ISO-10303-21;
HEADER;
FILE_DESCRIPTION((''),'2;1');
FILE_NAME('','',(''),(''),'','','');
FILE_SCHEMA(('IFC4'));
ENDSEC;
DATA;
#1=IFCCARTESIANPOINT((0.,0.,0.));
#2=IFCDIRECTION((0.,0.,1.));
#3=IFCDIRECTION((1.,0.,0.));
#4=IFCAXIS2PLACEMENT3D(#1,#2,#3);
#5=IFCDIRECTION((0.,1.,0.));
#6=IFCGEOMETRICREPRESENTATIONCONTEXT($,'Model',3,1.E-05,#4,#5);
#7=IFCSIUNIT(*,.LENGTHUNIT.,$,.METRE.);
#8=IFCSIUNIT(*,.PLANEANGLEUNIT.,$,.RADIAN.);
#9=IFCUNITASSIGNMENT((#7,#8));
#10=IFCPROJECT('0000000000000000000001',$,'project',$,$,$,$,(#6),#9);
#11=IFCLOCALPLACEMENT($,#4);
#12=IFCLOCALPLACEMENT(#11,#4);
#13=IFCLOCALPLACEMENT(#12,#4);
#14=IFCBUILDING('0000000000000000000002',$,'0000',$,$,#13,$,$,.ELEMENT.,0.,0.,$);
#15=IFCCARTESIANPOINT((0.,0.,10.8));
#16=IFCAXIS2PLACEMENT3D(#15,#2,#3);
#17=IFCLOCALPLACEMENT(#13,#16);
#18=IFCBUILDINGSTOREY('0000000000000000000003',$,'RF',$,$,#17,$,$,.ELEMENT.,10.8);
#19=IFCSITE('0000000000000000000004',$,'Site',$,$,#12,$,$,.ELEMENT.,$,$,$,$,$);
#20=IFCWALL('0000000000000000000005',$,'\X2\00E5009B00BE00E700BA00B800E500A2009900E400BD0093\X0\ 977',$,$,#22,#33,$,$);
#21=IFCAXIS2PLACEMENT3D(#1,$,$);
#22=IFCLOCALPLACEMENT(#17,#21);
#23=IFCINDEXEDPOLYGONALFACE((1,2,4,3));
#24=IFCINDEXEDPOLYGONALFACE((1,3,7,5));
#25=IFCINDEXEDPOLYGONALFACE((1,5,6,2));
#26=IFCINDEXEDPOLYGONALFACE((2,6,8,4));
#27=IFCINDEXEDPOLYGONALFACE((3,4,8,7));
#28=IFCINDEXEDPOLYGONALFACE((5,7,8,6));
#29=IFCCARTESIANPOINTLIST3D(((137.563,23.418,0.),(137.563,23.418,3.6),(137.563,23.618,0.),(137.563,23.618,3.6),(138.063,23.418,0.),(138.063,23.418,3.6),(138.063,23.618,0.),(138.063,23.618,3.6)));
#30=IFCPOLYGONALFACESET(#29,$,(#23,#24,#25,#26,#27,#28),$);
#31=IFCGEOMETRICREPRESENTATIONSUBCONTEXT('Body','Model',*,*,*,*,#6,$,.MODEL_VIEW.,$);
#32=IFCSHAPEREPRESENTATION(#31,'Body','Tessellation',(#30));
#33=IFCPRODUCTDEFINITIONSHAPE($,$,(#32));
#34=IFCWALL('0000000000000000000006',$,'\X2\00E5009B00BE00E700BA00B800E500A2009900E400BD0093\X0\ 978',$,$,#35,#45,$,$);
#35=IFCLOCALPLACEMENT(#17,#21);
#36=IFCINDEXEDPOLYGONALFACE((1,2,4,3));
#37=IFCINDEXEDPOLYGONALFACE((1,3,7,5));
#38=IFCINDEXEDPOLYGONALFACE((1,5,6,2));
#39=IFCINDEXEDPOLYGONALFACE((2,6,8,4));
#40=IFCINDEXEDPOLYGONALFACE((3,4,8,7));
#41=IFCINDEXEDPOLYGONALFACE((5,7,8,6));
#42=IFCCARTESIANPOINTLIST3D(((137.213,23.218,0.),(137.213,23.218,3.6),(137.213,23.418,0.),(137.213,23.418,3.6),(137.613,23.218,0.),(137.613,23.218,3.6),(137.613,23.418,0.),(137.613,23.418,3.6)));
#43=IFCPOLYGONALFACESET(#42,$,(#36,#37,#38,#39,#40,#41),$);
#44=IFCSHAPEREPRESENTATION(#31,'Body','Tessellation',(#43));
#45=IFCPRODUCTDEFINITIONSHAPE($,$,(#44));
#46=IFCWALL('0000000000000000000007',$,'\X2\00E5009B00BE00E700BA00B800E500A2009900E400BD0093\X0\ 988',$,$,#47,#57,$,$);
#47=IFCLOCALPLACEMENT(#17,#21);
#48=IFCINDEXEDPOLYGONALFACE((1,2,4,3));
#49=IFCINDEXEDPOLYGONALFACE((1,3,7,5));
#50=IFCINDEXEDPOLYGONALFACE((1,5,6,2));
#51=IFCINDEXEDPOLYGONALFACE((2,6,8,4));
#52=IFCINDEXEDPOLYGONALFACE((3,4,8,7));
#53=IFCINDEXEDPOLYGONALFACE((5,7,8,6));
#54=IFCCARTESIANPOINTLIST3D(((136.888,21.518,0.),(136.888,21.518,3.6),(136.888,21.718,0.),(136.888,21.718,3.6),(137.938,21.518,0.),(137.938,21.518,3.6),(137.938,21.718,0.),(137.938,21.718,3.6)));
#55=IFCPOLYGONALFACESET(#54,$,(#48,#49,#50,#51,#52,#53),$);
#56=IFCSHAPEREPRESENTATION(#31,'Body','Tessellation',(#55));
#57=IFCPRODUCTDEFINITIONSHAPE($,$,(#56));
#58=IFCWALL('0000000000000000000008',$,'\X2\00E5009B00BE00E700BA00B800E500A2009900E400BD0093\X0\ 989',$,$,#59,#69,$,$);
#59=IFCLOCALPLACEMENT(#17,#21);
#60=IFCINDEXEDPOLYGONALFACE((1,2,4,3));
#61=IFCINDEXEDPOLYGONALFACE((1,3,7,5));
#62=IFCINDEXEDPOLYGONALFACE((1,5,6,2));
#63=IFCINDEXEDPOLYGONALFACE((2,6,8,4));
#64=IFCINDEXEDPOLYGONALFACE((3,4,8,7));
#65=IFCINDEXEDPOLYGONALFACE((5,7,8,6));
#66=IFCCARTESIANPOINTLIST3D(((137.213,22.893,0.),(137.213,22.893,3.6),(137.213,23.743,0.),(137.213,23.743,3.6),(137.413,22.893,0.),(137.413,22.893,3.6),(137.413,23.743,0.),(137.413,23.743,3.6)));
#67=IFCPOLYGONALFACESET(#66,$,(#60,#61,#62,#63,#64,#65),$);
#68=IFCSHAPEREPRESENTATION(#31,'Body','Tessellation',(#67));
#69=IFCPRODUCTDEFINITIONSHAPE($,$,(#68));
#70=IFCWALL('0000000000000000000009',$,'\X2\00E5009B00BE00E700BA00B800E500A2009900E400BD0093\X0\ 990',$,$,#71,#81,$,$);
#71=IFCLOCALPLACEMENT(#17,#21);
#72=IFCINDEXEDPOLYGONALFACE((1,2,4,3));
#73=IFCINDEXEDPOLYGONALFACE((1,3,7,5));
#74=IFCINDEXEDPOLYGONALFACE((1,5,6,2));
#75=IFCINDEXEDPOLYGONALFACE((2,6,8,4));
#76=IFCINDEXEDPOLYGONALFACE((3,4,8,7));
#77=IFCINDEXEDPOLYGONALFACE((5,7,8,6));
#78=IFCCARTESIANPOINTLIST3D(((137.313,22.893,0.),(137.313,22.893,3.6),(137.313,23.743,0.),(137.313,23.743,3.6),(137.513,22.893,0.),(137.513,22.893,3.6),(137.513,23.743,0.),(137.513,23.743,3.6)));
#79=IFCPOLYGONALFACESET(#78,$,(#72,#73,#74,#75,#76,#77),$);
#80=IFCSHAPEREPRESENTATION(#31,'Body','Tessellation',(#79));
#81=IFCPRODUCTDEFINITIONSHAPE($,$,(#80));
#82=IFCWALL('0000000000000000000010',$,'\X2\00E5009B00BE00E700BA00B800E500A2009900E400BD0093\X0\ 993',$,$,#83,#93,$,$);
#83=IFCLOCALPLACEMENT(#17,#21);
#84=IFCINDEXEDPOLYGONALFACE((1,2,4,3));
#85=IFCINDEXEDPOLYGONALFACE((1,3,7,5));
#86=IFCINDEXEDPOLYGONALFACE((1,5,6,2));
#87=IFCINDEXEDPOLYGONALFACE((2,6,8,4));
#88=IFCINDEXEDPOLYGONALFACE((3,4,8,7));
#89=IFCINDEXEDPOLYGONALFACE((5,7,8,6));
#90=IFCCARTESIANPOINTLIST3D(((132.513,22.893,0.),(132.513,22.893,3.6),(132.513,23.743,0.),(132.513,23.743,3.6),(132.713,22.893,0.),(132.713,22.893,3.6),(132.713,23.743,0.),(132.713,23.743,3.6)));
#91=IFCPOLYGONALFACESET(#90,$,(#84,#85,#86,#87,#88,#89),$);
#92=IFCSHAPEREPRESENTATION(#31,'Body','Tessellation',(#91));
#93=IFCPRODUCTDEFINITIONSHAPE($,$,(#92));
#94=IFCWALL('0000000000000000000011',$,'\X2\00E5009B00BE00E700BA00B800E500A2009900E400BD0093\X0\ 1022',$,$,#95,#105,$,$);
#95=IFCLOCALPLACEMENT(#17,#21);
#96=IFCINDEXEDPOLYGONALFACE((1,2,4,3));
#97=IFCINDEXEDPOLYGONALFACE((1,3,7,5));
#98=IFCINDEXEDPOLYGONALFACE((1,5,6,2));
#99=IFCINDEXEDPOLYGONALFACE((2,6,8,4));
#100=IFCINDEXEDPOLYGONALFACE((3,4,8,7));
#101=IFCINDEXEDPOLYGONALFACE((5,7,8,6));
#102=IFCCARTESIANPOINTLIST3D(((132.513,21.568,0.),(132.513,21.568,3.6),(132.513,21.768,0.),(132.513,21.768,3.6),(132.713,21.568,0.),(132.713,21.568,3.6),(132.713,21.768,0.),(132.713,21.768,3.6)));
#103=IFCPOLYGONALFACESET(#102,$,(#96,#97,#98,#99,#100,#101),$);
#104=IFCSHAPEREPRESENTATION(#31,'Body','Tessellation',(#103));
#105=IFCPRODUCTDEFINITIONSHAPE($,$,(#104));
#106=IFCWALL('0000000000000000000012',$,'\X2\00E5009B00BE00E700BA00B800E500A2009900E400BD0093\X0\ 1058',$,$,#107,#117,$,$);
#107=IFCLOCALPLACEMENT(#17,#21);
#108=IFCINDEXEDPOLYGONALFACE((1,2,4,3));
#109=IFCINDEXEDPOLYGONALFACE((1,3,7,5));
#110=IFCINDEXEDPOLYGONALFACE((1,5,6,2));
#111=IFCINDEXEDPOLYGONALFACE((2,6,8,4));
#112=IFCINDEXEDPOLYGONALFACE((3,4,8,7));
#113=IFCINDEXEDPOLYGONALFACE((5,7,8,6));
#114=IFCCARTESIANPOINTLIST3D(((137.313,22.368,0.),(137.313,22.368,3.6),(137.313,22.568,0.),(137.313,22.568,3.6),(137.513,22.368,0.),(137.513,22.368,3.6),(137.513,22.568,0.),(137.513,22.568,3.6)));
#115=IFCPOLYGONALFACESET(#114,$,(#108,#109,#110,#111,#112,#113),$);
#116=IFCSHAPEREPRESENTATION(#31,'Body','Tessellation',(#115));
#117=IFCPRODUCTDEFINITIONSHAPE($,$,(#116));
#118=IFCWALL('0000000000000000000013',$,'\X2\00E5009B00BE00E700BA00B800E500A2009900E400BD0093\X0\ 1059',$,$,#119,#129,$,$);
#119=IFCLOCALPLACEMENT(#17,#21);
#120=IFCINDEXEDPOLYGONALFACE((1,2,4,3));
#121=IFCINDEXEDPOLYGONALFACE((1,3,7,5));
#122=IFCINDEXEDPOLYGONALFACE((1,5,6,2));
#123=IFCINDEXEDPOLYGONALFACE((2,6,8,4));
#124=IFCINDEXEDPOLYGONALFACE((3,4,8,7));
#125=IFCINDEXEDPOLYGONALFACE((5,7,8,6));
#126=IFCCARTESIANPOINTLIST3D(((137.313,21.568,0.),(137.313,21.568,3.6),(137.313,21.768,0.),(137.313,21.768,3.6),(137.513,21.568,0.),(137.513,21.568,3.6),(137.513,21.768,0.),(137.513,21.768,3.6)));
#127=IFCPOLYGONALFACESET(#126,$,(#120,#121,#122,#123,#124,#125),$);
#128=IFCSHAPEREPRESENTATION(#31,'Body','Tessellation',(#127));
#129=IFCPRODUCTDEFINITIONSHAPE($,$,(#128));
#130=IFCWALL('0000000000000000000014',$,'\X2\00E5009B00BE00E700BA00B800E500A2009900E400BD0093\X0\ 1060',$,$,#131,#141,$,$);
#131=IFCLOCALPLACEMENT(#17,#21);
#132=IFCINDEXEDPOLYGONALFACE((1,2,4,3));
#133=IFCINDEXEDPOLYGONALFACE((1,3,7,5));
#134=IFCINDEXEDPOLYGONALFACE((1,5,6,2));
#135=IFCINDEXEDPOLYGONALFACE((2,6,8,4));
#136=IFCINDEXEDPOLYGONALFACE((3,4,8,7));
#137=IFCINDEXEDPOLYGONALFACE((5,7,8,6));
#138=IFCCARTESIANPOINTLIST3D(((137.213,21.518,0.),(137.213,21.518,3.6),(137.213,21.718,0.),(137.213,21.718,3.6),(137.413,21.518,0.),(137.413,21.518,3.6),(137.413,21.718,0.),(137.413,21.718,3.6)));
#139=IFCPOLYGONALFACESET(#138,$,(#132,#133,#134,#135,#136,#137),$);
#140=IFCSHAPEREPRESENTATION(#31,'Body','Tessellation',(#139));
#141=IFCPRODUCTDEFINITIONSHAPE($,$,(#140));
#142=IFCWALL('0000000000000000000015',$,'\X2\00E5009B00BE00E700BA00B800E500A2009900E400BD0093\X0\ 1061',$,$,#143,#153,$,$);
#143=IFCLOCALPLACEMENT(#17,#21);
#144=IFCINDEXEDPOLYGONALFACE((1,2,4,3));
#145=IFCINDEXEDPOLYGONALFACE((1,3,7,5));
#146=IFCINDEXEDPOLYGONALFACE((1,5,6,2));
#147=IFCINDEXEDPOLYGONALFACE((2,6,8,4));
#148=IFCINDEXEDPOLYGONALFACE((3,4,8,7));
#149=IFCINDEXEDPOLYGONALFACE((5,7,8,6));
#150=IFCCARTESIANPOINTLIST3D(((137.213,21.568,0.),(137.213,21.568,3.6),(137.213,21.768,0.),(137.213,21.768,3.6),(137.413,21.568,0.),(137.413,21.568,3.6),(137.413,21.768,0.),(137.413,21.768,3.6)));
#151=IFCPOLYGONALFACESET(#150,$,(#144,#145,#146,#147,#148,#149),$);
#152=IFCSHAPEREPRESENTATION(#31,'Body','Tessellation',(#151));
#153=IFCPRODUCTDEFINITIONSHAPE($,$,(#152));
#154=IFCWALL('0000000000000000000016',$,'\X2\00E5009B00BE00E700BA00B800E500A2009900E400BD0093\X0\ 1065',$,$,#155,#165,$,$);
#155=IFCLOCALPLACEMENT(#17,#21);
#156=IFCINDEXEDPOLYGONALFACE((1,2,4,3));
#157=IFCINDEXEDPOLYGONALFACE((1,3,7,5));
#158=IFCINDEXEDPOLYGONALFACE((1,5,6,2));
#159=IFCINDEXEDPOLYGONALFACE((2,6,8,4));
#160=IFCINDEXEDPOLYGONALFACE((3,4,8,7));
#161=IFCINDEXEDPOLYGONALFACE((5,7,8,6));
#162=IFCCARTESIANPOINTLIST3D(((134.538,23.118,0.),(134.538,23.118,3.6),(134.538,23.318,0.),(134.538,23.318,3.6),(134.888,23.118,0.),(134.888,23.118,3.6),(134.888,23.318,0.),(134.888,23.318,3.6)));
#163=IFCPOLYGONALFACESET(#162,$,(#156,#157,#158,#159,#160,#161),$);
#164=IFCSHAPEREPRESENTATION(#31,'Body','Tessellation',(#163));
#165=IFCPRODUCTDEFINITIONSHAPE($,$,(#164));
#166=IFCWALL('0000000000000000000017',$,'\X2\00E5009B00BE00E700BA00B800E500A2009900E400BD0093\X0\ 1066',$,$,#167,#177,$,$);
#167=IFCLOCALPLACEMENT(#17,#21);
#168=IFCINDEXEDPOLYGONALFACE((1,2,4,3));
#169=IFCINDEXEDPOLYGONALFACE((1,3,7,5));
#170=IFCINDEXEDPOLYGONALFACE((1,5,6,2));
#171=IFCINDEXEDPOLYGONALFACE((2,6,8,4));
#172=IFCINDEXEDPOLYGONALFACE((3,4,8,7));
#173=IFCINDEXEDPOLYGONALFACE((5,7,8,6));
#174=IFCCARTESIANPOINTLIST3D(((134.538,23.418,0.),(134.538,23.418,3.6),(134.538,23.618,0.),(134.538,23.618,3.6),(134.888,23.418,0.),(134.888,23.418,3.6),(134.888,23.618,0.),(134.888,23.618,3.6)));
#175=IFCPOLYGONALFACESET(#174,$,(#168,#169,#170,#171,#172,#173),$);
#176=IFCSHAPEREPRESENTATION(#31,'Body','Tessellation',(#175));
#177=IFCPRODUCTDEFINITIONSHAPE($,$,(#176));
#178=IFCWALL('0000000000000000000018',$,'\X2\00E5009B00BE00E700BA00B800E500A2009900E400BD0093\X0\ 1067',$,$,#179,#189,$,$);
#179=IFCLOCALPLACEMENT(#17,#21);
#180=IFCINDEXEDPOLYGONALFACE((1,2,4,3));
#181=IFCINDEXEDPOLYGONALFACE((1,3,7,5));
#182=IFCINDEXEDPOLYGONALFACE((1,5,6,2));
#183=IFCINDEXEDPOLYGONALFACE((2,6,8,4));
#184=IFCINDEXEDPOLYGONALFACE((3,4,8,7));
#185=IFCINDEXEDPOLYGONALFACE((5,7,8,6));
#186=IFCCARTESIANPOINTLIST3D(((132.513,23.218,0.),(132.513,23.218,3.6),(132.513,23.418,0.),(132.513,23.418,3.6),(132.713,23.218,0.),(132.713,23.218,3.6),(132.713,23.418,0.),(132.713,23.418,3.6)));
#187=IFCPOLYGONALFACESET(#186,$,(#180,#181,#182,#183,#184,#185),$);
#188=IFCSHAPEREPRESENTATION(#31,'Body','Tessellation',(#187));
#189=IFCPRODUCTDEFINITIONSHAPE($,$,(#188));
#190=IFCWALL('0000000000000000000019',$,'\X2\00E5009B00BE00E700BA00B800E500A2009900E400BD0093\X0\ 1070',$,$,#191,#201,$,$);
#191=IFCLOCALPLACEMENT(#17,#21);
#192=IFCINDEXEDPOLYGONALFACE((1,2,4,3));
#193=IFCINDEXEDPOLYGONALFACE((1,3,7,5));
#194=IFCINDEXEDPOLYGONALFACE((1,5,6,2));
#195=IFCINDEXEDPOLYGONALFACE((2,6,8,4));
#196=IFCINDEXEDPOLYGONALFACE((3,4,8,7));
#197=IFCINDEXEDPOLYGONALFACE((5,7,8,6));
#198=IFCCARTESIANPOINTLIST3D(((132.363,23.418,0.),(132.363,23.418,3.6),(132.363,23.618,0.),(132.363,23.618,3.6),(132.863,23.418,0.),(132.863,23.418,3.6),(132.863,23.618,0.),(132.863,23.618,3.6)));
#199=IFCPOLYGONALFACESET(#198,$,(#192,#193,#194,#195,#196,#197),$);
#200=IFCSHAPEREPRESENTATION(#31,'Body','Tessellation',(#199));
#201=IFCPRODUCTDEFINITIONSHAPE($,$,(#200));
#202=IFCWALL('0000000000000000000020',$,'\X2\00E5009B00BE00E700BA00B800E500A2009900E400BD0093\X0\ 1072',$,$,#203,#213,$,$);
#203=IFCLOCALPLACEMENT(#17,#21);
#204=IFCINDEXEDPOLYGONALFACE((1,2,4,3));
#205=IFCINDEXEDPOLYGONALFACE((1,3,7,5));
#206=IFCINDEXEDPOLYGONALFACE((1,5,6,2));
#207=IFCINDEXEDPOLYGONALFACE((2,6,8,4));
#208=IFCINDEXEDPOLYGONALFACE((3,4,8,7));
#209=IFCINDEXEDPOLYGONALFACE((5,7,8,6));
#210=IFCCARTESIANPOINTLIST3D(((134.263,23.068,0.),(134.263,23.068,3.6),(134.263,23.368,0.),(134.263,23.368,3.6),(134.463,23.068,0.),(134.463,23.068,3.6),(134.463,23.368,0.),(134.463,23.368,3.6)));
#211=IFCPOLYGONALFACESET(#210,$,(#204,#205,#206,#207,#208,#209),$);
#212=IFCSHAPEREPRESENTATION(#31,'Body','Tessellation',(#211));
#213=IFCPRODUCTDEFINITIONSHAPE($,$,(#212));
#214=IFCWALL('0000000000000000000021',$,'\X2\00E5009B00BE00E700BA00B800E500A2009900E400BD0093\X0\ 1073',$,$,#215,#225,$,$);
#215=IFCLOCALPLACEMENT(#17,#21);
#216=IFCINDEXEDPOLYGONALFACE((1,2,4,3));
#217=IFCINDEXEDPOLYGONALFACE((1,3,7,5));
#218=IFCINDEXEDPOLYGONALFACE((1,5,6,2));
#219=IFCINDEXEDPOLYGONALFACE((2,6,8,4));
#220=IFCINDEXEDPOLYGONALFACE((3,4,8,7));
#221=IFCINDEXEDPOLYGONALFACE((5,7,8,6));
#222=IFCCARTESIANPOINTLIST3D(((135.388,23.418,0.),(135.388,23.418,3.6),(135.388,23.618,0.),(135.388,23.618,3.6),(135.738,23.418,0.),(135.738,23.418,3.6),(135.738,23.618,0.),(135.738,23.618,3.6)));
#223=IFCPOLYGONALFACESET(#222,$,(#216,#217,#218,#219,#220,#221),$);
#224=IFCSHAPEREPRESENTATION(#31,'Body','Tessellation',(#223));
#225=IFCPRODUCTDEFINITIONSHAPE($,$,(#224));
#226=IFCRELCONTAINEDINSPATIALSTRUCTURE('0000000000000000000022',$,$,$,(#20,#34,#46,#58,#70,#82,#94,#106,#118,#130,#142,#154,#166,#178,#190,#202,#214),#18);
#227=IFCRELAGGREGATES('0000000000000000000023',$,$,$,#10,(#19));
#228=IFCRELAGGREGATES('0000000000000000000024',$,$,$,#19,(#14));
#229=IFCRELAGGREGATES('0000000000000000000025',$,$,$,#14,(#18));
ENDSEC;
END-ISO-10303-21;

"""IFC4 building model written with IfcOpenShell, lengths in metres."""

from ifc_helpers import new_model, si_unit, direction, frame, frame_2d, origin_with_axes, place, context, subcontext, project, spatial, rectangle, extrude, element, save


model = new_model("IFC4")

# Units and contexts
model_context = context("Model", 3, precision=1e-05, world=origin_with_axes(), true_north=direction((0.0, 1.0, 0.0)))
body_context = subcontext(model_context, "Body", "Model", "MODEL_VIEW")
ifc_project = project(units=[si_unit("LENGTHUNIT", "METRE"), si_unit("PLANEANGLEUNIT", "RADIAN")], contexts=[model_context])

# Site, building, storey
placement = place(None, origin_with_axes())
site_placement = place(placement, origin_with_axes())
site = spatial("IfcSite", under=ifc_project, at=site_placement, Name="Site", CompositionType="ELEMENT")
building_placement = place(site_placement, origin_with_axes())
building = spatial("IfcBuilding", under=site, at=building_placement, Name="0000", CompositionType="ELEMENT", ElevationOfRefHeight=0.0, ElevationOfTerrain=0.0)
storey_placement = place(building_placement, frame((0.0, 0.0, 10.8), z_axis=(0.0, 0.0, 1.0), x_axis=(1.0, 0.0, 0.0)))
storey = spatial("IfcBuildingStorey", under=building, at=storey_placement, Name="RF", CompositionType="ELEMENT", Elevation=10.8)

# Walls
wall_1_placement = place(storey_placement, frame((137.813, 23.518, 0.0), z_axis=(0.0, 0.0, 1.0), x_axis=(-1.0, 0.0, 0.0)))
element("IfcWall", 1, at=wall_1_placement, inside=storey, Name="å\u009b¾çº¸å¢\u0099ä½\u0093 977", context=body_context, shape_type="SweptSolid", body=[
    extrude(rectangle(XDim=0.5, YDim=0.2, at=frame_2d((0.0, 0.0), x_axis=(1.0, 0.0, 0.0))), frame((0.0, 0.0, 0.0), z_axis=(0.0, 0.0, 1.0)), (0.0, 0.0, 1.0), 3.6),
])
wall_2_placement = place(storey_placement, frame((137.413, 23.318, 0.0), z_axis=(0.0, 0.0, 1.0), x_axis=(1.0, 0.0, 0.0)))
element("IfcWall", 2, at=wall_2_placement, inside=storey, Name="å\u009b¾çº¸å¢\u0099ä½\u0093 978", context=body_context, shape_type="SweptSolid", body=[
    extrude(rectangle(XDim=0.4, YDim=0.2, at=frame_2d((0.0, 0.0), x_axis=(1.0, 0.0, 0.0))), frame((0.0, 0.0, 0.0), z_axis=(0.0, 0.0, 1.0)), (0.0, 0.0, 1.0), 3.6),
])
wall_3_placement = place(storey_placement, frame((137.413, 21.618, 0.0), z_axis=(0.0, 0.0, 1.0), x_axis=(1.0, 0.0, 0.0)))
element("IfcWall", 3, at=wall_3_placement, inside=storey, Name="å\u009b¾çº¸å¢\u0099ä½\u0093 988", context=body_context, shape_type="SweptSolid", body=[
    extrude(rectangle(XDim=1.05, YDim=0.2, at=frame_2d((0.0, 0.0), x_axis=(1.0, 0.0, 0.0))), frame((0.0, 0.0, 0.0), z_axis=(0.0, 0.0, 1.0)), (0.0, 0.0, 1.0), 3.6),
])
for number, where, z_axis, x_axis, name in (
    (4, (137.313, 23.318, 0.0), (0.0, 0.0, 1.0), (0.0, -1.0, 0.0), "å\u009b¾çº¸å¢\u0099ä½\u0093 989"),
    (5, (137.413, 23.318, 0.0), (0.0, 0.0, 1.0), (0.0, -1.0, 0.0), "å\u009b¾çº¸å¢\u0099ä½\u0093 990"),
    (6, (132.613, 23.318, 0.0), (0.0, 0.0, 1.0), (0.0, -1.0, 0.0), "å\u009b¾çº¸å¢\u0099ä½\u0093 993"),
):
    element("IfcWall", number, at=place(storey_placement, frame(where, z_axis=z_axis, x_axis=x_axis)), inside=storey, Name=name, context=body_context, shape_type="SweptSolid", body=[
        extrude(rectangle(XDim=0.85, YDim=0.2, at=frame_2d((0.0, 0.0), x_axis=(1.0, 0.0, 0.0))), frame((0.0, 0.0, 0.0), z_axis=(0.0, 0.0, 1.0)), (0.0, 0.0, 1.0), 3.6),
    ])
for number, where, z_axis, x_axis, name in (
    (7, (132.613, 21.668, 0.0), (0.0, 0.0, 1.0), (0.0, -1.0, 0.0), "å\u009b¾çº¸å¢\u0099ä½\u0093 1022"),
    (8, (137.413, 22.468, 0.0), (0.0, 0.0, 1.0), (-1.0, 0.0, 0.0), "å\u009b¾çº¸å¢\u0099ä½\u0093 1058"),
    (9, (137.413, 21.668, 0.0), (0.0, 0.0, 1.0), (-1.0, 0.0, 0.0), "å\u009b¾çº¸å¢\u0099ä½\u0093 1059"),
    (10, (137.313, 21.618, 0.0), (0.0, 0.0, 1.0), (0.0, -1.0, 0.0), "å\u009b¾çº¸å¢\u0099ä½\u0093 1060"),
    (11, (137.313, 21.668, 0.0), (0.0, 0.0, 1.0), (0.0, -1.0, 0.0), "å\u009b¾çº¸å¢\u0099ä½\u0093 1061"),
):
    element("IfcWall", number, at=place(storey_placement, frame(where, z_axis=z_axis, x_axis=x_axis)), inside=storey, Name=name, context=body_context, shape_type="SweptSolid", body=[
        extrude(rectangle(XDim=0.2, YDim=0.2, at=frame_2d((0.0, 0.0), x_axis=(1.0, 0.0, 0.0))), frame((0.0, 0.0, 0.0), z_axis=(0.0, 0.0, 1.0)), (0.0, 0.0, 1.0), 3.6),
    ])
for number, where, z_axis, x_axis, name in (
    (12, (134.713, 23.218, 0.0), (0.0, 0.0, 1.0), (-1.0, 0.0, 0.0), "å\u009b¾çº¸å¢\u0099ä½\u0093 1065"),
    (13, (134.713, 23.518, 0.0), (0.0, 0.0, 1.0), (-1.0, 0.0, 0.0), "å\u009b¾çº¸å¢\u0099ä½\u0093 1066"),
):
    element("IfcWall", number, at=place(storey_placement, frame(where, z_axis=z_axis, x_axis=x_axis)), inside=storey, Name=name, context=body_context, shape_type="SweptSolid", body=[
        extrude(rectangle(XDim=0.35, YDim=0.2, at=frame_2d((0.0, 0.0), x_axis=(1.0, 0.0, 0.0))), frame((0.0, 0.0, 0.0), z_axis=(0.0, 0.0, 1.0)), (0.0, 0.0, 1.0), 3.6),
    ])
wall_4_placement = place(storey_placement, frame((132.613, 23.318, 0.0), z_axis=(0.0, 0.0, 1.0), x_axis=(0.0, 1.0, 0.0)))
element("IfcWall", 14, at=wall_4_placement, inside=storey, Name="å\u009b¾çº¸å¢\u0099ä½\u0093 1067", context=body_context, shape_type="SweptSolid", body=[
    extrude(rectangle(XDim=0.2, YDim=0.2, at=frame_2d((0.0, 0.0), x_axis=(1.0, 0.0, 0.0))), frame((0.0, 0.0, 0.0), z_axis=(0.0, 0.0, 1.0)), (0.0, 0.0, 1.0), 3.6),
])
wall_5_placement = place(storey_placement, frame((132.613, 23.518, 0.0), z_axis=(0.0, 0.0, 1.0), x_axis=(-1.0, 0.0, 0.0)))
element("IfcWall", 15, at=wall_5_placement, inside=storey, Name="å\u009b¾çº¸å¢\u0099ä½\u0093 1070", context=body_context, shape_type="SweptSolid", body=[
    extrude(rectangle(XDim=0.5, YDim=0.2, at=frame_2d((0.0, 0.0), x_axis=(1.0, 0.0, 0.0))), frame((0.0, 0.0, 0.0), z_axis=(0.0, 0.0, 1.0)), (0.0, 0.0, 1.0), 3.6),
])
wall_6_placement = place(storey_placement, frame((134.363, 23.218, 0.0), z_axis=(0.0, 0.0, 1.0), x_axis=(0.0, 1.0, 0.0)))
element("IfcWall", 16, at=wall_6_placement, inside=storey, Name="å\u009b¾çº¸å¢\u0099ä½\u0093 1072", context=body_context, shape_type="SweptSolid", body=[
    extrude(rectangle(XDim=0.3, YDim=0.2, at=frame_2d((0.0, 0.0), x_axis=(1.0, 0.0, 0.0))), frame((0.0, 0.0, 0.0), z_axis=(0.0, 0.0, 1.0)), (0.0, 0.0, 1.0), 3.6),
])
for number, where, z_axis, x_axis, name in (
    (17, (135.563, 23.518, 0.0), (0.0, 0.0, 1.0), (-1.0, 0.0, 0.0), "å\u009b¾çº¸å¢\u0099ä½\u0093 1073"),
):
    element("IfcWall", number, at=place(storey_placement, frame(where, z_axis=z_axis, x_axis=x_axis)), inside=storey, Name=name, context=body_context, shape_type="SweptSolid", body=[
        extrude(rectangle(XDim=0.35, YDim=0.2, at=frame_2d((0.0, 0.0), x_axis=(1.0, 0.0, 0.0))), frame((0.0, 0.0, 0.0), z_axis=(0.0, 0.0, 1.0)), (0.0, 0.0, 1.0), 3.6),
    ])

save(model, "model.ifc")
